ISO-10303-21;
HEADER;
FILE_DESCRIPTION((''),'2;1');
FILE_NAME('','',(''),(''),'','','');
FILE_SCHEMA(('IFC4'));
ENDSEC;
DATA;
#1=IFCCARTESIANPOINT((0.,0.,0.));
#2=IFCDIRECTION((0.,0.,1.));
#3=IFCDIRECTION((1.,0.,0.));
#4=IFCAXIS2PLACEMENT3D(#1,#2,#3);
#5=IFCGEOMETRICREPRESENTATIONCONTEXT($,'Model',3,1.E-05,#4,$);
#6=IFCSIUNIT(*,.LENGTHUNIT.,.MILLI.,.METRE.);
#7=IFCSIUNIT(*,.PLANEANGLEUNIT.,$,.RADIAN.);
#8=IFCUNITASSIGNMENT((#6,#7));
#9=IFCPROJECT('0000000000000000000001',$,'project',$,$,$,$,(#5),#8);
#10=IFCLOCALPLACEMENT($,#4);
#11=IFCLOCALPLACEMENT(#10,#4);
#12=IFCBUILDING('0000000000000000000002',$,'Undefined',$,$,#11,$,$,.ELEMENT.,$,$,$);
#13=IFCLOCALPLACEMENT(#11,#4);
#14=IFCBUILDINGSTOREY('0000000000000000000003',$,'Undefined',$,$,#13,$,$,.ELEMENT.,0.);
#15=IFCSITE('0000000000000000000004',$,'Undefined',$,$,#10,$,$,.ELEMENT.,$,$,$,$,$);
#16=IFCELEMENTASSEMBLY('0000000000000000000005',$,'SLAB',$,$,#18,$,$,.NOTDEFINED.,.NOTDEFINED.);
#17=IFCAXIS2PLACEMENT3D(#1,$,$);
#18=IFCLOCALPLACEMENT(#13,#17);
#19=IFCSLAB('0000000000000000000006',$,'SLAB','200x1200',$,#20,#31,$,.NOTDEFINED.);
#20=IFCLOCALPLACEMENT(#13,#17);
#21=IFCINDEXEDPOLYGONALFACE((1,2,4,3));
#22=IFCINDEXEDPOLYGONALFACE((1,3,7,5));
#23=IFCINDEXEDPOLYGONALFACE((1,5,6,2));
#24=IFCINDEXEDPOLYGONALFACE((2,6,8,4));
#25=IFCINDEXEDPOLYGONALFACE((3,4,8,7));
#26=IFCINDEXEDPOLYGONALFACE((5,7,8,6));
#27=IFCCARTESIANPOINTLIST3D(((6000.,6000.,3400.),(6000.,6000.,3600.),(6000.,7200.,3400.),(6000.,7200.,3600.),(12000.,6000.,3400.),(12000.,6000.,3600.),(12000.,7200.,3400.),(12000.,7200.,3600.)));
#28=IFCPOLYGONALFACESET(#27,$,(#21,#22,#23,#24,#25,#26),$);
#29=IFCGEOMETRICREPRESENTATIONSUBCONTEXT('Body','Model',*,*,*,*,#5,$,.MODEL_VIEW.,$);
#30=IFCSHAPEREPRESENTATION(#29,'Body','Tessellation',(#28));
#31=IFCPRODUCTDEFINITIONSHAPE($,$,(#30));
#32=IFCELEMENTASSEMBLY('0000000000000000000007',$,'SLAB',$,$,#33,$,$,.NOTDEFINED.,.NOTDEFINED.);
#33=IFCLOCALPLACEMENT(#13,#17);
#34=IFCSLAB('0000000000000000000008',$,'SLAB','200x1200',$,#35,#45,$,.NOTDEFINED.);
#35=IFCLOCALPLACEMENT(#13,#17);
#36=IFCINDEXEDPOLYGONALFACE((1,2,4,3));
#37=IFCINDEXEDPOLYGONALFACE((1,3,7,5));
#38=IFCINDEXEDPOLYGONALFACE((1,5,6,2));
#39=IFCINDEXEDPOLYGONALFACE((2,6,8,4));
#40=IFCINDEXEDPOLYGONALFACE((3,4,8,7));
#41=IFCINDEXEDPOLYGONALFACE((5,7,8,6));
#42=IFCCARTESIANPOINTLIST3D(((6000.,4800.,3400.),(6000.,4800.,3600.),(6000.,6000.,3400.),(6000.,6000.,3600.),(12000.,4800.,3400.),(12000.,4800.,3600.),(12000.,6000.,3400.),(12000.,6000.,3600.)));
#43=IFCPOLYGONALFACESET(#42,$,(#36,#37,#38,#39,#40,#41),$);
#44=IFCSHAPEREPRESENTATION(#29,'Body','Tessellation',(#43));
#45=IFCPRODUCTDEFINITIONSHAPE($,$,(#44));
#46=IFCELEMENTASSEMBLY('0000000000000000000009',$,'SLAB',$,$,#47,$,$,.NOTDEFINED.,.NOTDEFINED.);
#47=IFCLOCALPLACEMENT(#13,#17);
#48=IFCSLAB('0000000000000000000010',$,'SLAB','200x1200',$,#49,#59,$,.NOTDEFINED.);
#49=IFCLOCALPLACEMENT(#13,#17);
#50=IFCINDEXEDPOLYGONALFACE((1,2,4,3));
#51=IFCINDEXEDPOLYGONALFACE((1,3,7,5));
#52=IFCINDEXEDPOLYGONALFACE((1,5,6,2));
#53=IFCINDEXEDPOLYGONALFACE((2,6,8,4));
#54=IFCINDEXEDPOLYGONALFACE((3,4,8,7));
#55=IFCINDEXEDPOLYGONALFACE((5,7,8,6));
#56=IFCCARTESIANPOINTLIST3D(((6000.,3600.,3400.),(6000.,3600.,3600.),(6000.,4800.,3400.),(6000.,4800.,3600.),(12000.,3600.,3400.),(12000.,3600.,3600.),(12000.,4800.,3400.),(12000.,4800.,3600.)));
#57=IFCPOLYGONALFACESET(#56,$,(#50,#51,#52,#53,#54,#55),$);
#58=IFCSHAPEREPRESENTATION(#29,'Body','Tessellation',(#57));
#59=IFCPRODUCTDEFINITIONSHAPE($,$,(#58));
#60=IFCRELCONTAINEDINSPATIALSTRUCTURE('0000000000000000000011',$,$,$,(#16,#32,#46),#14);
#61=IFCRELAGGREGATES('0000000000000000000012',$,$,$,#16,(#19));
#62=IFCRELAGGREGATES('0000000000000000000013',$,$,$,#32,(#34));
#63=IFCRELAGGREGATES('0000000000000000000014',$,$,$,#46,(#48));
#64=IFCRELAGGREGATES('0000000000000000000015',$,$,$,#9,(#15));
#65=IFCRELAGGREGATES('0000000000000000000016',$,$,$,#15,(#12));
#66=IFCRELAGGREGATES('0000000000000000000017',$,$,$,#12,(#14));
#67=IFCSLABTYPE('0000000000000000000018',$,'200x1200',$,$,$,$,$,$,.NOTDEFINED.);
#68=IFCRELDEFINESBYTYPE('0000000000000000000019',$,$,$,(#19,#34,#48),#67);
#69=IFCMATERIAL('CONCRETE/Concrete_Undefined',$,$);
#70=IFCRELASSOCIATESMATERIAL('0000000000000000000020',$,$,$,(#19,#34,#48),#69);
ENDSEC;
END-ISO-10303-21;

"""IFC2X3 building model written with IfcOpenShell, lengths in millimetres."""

from ifc_helpers import new_model, si_unit, frame, origin_with_axes, place, context, subcontext, project, spatial, polyline, outline, extrude, material, type_object, element, aggregate, save


model = new_model("IFC2X3")

# Units and contexts
model_context = context("Model", 3, precision=1e-05, world=origin_with_axes())
body_context = subcontext(model_context, "Body", "Model", "MODEL_VIEW")
ifc_project = project(units=[si_unit("LENGTHUNIT", "METRE", prefix="MILLI"), si_unit("PLANEANGLEUNIT", "RADIAN")], contexts=[model_context])

# Site, building, storey
site_placement = place(None, origin_with_axes())
site = spatial("IfcSite", under=ifc_project, at=site_placement, Name="Undefined", CompositionType="ELEMENT")
building_placement = place(site_placement, origin_with_axes())
building = spatial("IfcBuilding", under=site, at=building_placement, Name="Undefined", CompositionType="ELEMENT")
storey_placement = place(building_placement, origin_with_axes())
storey = spatial("IfcBuildingStorey", under=building, at=storey_placement, Name="Undefined", CompositionType="ELEMENT", Elevation=0.0)

# Element assemblies, slabs
ifc_material_1 = material(Name="CONCRETE/Concrete_Undefined")
slab_type = type_object("IfcSlabType", Name="200x1200", PredefinedType="NOTDEFINED")
assembly_1_placement = place(storey_placement, origin_with_axes())
assembly_1 = element("IfcElementAssembly", 1, at=assembly_1_placement, inside=storey, Name="SLAB", AssemblyPlace="NOTDEFINED", PredefinedType="NOTDEFINED")
slab_1_placement = place(assembly_1_placement, frame((12000.0, 6000.0, 3500.0), z_axis=(0.0, 0.0, 1.0), x_axis=(0.0, 1.0, 0.0)))
slab_1 = element("IfcSlab", 2, at=slab_1_placement, type_object=slab_type, material=ifc_material_1, Name="SLAB", Description="200x1200", PredefinedType="NOTDEFINED", context=body_context, shape_type="SweptSolid", body=[
    extrude(outline(polyline([(0.0, 0.0), (1200.0, 0.0), (1200.0, 6000.0), (0.0, 6000.0), (0.0, 0.0)])), frame((0.0, 0.0, -100.0), z_axis=(0.0, 0.0, 1.0), x_axis=(1.0, 0.0, 0.0)), (0.0, 0.0, 1.0), 200.0),
])
aggregate(assembly_1, [slab_1])
assembly_2_placement = place(storey_placement, origin_with_axes())
assembly_2 = element("IfcElementAssembly", 3, at=assembly_2_placement, inside=storey, Name="SLAB", AssemblyPlace="NOTDEFINED", PredefinedType="NOTDEFINED")
slab_2_placement = place(assembly_2_placement, frame((12000.0, 4800.0, 3500.0), z_axis=(0.0, 0.0, 1.0), x_axis=(0.0, 1.0, 0.0)))
slab_2 = element("IfcSlab", 4, at=slab_2_placement, type_object=slab_type, material=ifc_material_1, Name="SLAB", Description="200x1200", PredefinedType="NOTDEFINED", context=body_context, shape_type="SweptSolid", body=[
    extrude(outline(polyline([(0.0, 0.0), (1200.0, 0.0), (1200.0, 6000.0), (0.0, 6000.0), (0.0, 0.0)])), frame((0.0, 0.0, -100.0), z_axis=(0.0, 0.0, 1.0), x_axis=(1.0, 0.0, 0.0)), (0.0, 0.0, 1.0), 200.0),
])
aggregate(assembly_2, [slab_2])
assembly_3_placement = place(storey_placement, origin_with_axes())
assembly_3 = element("IfcElementAssembly", 5, at=assembly_3_placement, inside=storey, Name="SLAB", AssemblyPlace="NOTDEFINED", PredefinedType="NOTDEFINED")
slab_3_placement = place(assembly_3_placement, frame((12000.0, 3600.0, 3500.0), z_axis=(0.0, 0.0, 1.0), x_axis=(0.0, 1.0, 0.0)))
slab_3 = element("IfcSlab", 6, at=slab_3_placement, type_object=slab_type, material=ifc_material_1, Name="SLAB", Description="200x1200", PredefinedType="NOTDEFINED", context=body_context, shape_type="SweptSolid", body=[
    extrude(outline(polyline([(0.0, 0.0), (1200.0, 0.0), (1200.0, 6000.0), (0.0, 6000.0), (0.0, 0.0)])), frame((0.0, 0.0, -100.0), z_axis=(0.0, 0.0, 1.0), x_axis=(1.0, 0.0, 0.0)), (0.0, 0.0, 1.0), 200.0),
])
aggregate(assembly_3, [slab_3])

save(model, "model.ifc")
